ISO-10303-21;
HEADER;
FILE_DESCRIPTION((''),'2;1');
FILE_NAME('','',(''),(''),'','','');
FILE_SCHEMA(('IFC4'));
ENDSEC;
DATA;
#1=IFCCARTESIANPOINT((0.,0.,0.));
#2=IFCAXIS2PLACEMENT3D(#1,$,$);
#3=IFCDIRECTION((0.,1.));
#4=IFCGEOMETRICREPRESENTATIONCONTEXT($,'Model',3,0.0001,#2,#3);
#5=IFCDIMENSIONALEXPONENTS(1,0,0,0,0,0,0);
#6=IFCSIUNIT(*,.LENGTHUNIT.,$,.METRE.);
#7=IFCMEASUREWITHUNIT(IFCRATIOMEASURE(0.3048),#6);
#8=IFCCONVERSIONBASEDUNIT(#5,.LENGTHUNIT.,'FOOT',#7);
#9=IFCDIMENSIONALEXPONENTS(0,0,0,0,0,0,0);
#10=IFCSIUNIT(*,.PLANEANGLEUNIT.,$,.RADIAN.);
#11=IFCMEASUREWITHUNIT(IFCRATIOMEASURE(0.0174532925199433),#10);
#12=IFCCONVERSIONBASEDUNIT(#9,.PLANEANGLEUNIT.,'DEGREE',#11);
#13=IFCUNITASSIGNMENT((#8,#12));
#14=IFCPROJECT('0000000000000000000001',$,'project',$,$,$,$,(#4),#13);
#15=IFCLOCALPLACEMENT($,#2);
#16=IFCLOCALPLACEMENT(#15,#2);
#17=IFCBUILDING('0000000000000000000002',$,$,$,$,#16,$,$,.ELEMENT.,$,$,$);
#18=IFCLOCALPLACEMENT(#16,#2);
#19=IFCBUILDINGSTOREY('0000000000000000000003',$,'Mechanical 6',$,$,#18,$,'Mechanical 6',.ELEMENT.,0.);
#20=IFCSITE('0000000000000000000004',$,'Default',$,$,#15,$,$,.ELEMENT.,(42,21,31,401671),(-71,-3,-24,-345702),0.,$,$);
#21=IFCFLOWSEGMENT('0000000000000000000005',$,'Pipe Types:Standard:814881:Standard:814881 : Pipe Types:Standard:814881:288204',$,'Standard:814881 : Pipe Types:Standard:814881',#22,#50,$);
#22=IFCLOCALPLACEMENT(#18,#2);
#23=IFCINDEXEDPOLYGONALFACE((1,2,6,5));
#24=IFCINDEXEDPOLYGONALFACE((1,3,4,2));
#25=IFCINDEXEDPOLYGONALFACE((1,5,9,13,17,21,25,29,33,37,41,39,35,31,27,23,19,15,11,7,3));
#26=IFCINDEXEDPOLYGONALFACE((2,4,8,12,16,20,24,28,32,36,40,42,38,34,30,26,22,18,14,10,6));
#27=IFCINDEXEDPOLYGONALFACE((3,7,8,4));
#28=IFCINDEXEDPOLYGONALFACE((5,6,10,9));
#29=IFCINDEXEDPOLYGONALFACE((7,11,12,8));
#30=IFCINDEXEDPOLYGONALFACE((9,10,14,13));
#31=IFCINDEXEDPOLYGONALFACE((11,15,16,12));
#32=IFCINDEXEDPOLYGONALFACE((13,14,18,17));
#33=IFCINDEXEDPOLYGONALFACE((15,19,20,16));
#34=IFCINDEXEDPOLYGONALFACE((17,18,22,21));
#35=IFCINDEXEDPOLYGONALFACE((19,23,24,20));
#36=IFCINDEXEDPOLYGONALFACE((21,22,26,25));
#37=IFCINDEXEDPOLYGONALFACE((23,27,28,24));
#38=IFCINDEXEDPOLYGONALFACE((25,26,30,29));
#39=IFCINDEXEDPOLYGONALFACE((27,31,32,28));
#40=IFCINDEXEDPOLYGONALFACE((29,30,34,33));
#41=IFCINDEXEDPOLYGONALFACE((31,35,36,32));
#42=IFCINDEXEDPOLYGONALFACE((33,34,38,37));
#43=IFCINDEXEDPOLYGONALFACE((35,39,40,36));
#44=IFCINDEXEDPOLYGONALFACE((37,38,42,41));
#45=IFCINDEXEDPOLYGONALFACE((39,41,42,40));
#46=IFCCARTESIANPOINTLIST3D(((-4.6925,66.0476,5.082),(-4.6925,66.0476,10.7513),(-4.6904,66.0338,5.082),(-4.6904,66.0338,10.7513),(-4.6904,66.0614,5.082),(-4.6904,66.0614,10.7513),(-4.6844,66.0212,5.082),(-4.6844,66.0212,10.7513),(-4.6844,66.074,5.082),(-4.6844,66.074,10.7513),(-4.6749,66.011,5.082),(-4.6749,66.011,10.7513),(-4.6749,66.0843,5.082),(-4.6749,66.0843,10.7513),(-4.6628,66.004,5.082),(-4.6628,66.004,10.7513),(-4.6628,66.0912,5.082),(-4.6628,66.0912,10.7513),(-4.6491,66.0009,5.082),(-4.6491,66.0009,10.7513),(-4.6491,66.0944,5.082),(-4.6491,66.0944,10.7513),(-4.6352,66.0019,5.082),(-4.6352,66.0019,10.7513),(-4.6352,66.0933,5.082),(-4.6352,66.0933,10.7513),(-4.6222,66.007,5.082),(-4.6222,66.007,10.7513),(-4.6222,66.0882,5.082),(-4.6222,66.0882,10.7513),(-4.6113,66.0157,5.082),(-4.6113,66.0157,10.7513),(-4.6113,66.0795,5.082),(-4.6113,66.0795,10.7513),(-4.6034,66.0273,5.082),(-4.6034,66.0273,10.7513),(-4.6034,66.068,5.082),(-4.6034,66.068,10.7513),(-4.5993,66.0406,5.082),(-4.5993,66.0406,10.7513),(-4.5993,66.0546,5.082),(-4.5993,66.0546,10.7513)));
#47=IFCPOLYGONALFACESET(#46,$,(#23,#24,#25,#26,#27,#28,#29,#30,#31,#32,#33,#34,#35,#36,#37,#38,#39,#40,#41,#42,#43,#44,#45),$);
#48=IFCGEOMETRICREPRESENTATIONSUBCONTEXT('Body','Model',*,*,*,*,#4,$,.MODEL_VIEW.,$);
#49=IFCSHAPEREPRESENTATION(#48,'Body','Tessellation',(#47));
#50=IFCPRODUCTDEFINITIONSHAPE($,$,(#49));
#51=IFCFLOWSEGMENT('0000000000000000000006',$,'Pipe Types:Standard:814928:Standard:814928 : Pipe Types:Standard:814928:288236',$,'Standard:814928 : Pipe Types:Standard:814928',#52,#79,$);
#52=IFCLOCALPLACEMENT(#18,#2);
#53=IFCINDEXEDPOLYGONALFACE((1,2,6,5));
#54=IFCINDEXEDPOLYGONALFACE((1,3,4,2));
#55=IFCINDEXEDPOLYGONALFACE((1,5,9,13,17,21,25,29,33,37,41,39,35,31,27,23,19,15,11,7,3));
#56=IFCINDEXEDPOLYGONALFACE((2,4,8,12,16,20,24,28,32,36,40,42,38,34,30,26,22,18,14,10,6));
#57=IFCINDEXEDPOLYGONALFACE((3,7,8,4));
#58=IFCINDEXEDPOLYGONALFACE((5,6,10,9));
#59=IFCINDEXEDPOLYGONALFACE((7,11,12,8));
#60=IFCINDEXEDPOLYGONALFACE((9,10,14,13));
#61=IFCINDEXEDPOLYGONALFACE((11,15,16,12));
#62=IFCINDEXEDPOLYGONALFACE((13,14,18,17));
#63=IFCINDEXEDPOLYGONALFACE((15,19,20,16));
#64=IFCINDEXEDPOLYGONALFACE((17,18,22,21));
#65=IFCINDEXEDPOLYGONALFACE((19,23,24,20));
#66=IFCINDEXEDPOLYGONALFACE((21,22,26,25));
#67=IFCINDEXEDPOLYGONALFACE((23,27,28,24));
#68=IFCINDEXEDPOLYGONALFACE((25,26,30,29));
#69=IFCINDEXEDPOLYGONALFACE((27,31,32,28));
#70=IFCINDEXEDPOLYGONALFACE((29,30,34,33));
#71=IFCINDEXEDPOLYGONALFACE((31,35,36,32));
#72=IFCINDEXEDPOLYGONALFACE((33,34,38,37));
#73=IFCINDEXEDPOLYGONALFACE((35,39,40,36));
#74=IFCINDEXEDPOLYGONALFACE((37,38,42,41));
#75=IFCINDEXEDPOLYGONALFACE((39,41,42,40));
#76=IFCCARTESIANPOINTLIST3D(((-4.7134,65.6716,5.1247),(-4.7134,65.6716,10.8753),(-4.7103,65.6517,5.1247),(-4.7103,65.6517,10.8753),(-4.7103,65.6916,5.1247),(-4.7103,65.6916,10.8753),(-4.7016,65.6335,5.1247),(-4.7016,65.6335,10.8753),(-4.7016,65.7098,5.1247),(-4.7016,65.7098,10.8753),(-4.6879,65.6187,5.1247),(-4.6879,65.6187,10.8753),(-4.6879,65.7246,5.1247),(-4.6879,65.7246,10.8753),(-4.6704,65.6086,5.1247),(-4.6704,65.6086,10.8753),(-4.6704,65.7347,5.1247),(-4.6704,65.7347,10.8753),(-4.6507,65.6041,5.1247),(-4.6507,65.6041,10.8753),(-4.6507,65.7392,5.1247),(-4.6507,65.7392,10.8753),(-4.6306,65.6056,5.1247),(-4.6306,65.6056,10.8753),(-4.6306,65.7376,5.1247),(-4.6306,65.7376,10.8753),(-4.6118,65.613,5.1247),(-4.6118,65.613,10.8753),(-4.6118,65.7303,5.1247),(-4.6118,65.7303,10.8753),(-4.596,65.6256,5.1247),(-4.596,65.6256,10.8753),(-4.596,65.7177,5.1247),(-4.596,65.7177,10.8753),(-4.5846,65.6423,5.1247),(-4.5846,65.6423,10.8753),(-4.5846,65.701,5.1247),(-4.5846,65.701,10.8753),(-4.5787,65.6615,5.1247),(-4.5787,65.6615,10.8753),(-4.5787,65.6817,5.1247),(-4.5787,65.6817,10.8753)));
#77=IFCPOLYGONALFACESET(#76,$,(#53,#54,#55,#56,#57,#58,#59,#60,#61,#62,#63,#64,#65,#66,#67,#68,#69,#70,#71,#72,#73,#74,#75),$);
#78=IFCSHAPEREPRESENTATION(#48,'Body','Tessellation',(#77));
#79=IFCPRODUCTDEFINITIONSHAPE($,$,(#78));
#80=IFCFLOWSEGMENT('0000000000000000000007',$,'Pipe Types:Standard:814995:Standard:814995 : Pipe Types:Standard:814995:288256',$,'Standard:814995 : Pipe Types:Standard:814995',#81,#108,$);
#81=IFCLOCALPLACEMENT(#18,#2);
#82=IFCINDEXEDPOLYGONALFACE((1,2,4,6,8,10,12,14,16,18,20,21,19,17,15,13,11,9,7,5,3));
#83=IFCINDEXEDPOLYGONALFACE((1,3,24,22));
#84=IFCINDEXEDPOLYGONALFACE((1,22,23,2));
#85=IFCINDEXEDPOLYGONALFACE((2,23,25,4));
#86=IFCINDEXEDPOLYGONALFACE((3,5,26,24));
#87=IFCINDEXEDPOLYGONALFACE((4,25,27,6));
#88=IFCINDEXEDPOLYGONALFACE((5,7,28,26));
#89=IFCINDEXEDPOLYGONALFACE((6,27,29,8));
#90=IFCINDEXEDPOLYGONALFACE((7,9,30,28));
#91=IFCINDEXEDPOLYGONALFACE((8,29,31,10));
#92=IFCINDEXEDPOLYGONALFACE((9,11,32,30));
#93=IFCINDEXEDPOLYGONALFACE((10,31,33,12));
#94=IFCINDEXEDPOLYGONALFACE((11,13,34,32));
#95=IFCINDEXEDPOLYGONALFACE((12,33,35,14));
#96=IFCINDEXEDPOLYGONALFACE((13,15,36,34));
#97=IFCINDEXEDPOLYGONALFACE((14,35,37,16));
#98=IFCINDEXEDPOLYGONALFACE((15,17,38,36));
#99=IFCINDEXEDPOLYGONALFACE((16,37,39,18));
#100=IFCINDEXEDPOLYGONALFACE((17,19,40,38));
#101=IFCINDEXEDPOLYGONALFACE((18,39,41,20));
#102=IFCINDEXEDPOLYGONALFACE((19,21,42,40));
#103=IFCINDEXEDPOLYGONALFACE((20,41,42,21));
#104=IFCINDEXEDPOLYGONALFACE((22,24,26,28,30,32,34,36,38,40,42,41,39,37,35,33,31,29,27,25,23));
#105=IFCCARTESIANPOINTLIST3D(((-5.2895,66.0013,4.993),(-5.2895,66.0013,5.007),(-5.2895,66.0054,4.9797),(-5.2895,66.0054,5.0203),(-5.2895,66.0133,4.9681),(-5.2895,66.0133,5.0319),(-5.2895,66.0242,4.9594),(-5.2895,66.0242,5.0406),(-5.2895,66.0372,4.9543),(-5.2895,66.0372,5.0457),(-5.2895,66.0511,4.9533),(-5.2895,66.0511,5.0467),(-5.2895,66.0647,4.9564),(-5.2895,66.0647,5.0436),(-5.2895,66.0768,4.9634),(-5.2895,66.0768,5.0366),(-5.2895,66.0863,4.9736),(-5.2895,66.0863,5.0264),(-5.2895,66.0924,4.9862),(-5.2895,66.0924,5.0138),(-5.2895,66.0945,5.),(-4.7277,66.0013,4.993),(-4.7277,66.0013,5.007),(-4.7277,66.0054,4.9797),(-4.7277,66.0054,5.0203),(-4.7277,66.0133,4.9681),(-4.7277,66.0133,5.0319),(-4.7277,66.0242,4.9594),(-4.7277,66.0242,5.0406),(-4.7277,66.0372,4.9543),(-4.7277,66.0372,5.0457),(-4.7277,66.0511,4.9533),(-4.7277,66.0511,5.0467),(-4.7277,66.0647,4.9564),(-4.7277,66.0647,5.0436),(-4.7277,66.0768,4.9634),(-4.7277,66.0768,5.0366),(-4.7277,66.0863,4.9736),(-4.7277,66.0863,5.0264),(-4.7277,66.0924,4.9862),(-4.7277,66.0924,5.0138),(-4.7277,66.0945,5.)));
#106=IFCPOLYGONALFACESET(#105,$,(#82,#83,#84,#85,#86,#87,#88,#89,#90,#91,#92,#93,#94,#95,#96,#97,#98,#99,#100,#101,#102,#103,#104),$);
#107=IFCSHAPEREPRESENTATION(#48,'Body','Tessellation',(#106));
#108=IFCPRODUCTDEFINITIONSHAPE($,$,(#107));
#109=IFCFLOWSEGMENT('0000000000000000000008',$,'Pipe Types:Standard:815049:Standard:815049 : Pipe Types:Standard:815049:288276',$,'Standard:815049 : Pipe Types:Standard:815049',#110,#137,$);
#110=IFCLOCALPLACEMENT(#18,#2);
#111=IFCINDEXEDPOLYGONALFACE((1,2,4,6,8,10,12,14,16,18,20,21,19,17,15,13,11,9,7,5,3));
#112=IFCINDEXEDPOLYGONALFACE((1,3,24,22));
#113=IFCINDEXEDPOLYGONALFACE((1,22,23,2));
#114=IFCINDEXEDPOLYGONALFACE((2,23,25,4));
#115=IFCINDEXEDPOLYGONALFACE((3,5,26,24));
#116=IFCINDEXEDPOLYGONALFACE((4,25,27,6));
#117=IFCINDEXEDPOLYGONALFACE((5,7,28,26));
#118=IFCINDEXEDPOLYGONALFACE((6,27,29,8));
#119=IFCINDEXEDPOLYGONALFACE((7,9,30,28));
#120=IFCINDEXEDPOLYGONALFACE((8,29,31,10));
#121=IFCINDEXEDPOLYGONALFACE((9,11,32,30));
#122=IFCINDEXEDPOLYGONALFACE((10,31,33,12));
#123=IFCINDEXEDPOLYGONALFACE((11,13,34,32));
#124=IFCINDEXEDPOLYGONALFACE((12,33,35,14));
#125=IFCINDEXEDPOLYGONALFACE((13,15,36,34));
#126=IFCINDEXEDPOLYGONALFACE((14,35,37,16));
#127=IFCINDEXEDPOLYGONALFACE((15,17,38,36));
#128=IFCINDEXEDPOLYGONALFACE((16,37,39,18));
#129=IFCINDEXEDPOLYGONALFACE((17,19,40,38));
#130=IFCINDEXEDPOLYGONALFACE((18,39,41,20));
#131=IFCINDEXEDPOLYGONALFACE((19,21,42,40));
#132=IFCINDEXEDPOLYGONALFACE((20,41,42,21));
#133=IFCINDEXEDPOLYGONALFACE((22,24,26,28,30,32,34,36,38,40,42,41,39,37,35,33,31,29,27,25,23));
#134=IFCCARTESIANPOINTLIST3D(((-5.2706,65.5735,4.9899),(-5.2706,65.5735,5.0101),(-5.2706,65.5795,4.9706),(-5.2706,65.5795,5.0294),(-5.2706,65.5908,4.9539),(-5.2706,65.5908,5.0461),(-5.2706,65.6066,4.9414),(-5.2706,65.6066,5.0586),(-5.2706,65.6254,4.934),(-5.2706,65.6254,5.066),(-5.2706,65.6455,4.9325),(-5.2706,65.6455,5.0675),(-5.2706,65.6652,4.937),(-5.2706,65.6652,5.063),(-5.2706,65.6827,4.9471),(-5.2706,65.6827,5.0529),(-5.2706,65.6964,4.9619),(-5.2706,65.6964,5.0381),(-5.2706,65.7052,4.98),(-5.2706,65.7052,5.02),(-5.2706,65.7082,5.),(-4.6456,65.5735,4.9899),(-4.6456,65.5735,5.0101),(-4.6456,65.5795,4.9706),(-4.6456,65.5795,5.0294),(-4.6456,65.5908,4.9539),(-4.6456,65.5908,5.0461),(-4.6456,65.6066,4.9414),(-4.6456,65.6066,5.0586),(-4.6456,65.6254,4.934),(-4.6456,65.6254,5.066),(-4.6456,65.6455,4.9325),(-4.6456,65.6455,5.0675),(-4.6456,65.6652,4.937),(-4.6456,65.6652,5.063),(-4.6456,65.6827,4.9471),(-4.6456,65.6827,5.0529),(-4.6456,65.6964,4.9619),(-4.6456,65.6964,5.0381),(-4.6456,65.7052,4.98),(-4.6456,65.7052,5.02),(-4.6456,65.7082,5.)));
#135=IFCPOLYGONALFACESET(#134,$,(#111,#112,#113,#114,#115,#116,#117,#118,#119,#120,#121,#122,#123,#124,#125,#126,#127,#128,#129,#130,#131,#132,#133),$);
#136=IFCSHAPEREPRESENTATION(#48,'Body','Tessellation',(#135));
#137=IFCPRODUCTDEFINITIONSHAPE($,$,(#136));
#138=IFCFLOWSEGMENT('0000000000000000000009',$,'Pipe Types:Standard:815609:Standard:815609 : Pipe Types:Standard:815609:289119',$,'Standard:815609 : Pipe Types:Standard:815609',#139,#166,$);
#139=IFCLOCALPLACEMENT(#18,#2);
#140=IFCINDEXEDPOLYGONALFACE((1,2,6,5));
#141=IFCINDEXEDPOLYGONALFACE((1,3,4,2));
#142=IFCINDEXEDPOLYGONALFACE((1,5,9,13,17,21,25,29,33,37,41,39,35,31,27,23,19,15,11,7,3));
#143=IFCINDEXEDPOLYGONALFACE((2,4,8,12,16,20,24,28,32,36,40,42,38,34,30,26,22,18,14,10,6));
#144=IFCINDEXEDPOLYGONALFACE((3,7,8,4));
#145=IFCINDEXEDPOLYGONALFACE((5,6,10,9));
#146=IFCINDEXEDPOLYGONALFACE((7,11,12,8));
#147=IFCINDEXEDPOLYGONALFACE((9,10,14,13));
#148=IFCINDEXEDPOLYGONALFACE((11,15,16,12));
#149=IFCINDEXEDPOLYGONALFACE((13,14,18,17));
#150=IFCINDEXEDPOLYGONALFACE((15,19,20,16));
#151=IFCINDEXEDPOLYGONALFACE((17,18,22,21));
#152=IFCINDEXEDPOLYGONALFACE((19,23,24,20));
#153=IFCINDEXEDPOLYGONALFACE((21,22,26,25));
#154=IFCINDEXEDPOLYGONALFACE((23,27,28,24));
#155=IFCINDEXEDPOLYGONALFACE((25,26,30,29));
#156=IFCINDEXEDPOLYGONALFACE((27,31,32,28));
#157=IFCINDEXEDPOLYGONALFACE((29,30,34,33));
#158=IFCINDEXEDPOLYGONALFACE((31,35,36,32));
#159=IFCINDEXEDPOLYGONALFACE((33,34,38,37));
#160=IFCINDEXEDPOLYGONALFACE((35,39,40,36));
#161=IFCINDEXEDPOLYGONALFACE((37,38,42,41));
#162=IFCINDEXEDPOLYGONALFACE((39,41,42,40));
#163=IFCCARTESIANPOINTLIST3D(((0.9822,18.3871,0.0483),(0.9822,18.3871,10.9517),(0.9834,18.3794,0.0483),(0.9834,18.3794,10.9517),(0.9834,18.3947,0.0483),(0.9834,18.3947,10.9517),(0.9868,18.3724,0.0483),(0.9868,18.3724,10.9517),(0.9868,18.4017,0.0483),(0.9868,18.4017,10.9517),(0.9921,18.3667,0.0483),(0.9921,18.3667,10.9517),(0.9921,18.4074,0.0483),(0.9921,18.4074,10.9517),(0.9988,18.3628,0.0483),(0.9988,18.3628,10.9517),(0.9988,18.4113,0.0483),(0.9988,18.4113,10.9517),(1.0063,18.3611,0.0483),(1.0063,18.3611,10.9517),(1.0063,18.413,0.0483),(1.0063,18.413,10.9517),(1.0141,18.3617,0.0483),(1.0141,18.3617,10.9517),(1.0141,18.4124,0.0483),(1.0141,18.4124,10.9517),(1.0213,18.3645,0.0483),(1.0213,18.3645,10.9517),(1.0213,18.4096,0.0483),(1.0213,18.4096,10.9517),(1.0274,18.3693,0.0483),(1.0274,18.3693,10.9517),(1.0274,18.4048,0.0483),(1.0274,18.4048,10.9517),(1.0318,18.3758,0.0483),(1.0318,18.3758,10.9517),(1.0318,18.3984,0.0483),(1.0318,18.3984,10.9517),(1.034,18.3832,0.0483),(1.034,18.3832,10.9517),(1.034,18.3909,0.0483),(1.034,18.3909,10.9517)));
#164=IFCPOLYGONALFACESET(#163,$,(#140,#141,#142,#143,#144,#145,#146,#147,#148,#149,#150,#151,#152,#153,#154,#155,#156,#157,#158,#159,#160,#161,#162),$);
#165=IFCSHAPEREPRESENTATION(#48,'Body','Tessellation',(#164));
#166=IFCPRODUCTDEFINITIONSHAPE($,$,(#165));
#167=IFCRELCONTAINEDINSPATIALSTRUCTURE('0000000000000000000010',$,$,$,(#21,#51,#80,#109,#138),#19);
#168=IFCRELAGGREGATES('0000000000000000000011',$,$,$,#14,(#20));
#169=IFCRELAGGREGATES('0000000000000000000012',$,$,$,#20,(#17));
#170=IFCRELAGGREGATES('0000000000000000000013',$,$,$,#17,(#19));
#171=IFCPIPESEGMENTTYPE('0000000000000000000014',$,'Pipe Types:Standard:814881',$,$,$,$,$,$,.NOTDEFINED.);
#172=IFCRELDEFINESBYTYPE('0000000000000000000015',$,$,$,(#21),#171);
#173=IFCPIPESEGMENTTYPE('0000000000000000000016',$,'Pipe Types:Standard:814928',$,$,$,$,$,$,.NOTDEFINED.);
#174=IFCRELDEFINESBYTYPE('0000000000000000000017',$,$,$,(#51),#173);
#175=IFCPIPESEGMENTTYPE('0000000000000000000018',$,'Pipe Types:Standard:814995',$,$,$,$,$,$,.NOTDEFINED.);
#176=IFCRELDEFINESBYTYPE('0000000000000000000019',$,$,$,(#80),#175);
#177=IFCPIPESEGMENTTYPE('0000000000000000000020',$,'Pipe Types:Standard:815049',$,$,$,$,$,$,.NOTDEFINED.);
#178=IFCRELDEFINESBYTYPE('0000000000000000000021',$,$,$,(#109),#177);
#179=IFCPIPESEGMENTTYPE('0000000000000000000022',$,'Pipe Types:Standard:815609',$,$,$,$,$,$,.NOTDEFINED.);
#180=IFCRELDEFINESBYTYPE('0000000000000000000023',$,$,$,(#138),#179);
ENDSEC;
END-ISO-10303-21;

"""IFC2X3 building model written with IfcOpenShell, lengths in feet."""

from ifc_helpers import new_model, entity, si_unit, converted_unit, direction, frame, origin, origin_2d_with_axis, place, context, subcontext, project, spatial, circle, extrude, source, transform, mapped, type_object, type_shapes, element, save


model = new_model("IFC2X3")

# Units and contexts
model_context = context("Model", 3, precision=0.0001, world=origin(), true_north=direction((0.0, 1.0)))
body_context = subcontext(model_context, "Body", "Model", "MODEL_VIEW")
ifc_project = project(units=[converted_unit("LENGTHUNIT", "FOOT", entity("IfcRatioMeasure", 0.3048), si_unit("LENGTHUNIT", "METRE"), dimensions=[1, 0, 0, 0, 0, 0, 0]), converted_unit("PLANEANGLEUNIT", "DEGREE", entity("IfcRatioMeasure", 0.0174532925199433), si_unit("PLANEANGLEUNIT", "RADIAN"), dimensions=[0, 0, 0, 0, 0, 0, 0])], contexts=[model_context])

# Site, building, storey
site_placement = place(None, origin())
site = spatial("IfcSite", under=ifc_project, at=site_placement, Name="Default", CompositionType="ELEMENT", RefLatitude=(42, 21, 31, 401671), RefLongitude=(-71, -3, -24, -345702), RefElevation=0.0)
building_placement = place(site_placement, origin())
building = spatial("IfcBuilding", under=site, at=building_placement, CompositionType="ELEMENT")
storey_placement = place(building_placement, origin())
storey = spatial("IfcBuildingStorey", under=building, at=storey_placement, Name="Mechanical 6", LongName="Mechanical 6", CompositionType="ELEMENT", Elevation=0.0)

# Flow segments
pipe_segment_type_1 = type_object("IfcPipeSegmentType", Name="Pipe Types:Standard:814881", PredefinedType="NOTDEFINED")
shared_shape_1 = source(origin(), body_context, "Body", "SweptSolid", [
    extrude(circle(Radius=0.0469, at=origin_2d_with_axis()), frame((-4.6456, 66.0476, 5.082), z_axis=(0.0, 0.0, 1.0), x_axis=(-1.0, 0.0, 0.0)), (0.0, 0.0, 1.0), 5.6693),
])
type_shapes(pipe_segment_type_1, [shared_shape_1])
flow_segment_1_placement = place(building_placement, origin())
element("IfcFlowSegment", 1, at=flow_segment_1_placement, inside=storey, type_object=pipe_segment_type_1, Name="Pipe Types:Standard:814881:Standard:814881 : Pipe Types:Standard:814881:288204", ObjectType="Standard:814881 : Pipe Types:Standard:814881", context=body_context, shape_type="MappedRepresentation", body=[
    mapped(shared_shape_1, transform((0.0, 0.0, 0.0), scale=1.0)),
])
pipe_segment_type_2 = type_object("IfcPipeSegmentType", Name="Pipe Types:Standard:814928", PredefinedType="NOTDEFINED")
shared_shape_2 = source(origin(), body_context, "Body", "SweptSolid", [
    extrude(circle(Radius=0.0677, at=origin_2d_with_axis()), frame((-4.6456, 65.6716, 5.1247), z_axis=(0.0, 0.0, 1.0), x_axis=(-1.0, 0.0, 0.0)), (0.0, 0.0, 1.0), 5.7507),
])
type_shapes(pipe_segment_type_2, [shared_shape_2])
flow_segment_2_placement = place(building_placement, origin())
element("IfcFlowSegment", 2, at=flow_segment_2_placement, inside=storey, type_object=pipe_segment_type_2, Name="Pipe Types:Standard:814928:Standard:814928 : Pipe Types:Standard:814928:288236", ObjectType="Standard:814928 : Pipe Types:Standard:814928", context=body_context, shape_type="MappedRepresentation", body=[
    mapped(shared_shape_2, transform((0.0, 0.0, 0.0), scale=1.0)),
])
pipe_segment_type_3 = type_object("IfcPipeSegmentType", Name="Pipe Types:Standard:814995", PredefinedType="NOTDEFINED")
shared_shape_3 = source(origin(), body_context, "Body", "SweptSolid", [
    extrude(circle(Radius=0.0469, at=origin_2d_with_axis()), frame((-5.2895, 66.0476, 5.0), z_axis=(1.0, 0.0, 0.0), x_axis=(0.0, 1.0, 0.0)), (0.0, 0.0, 1.0), 0.5618),
])
type_shapes(pipe_segment_type_3, [shared_shape_3])
flow_segment_3_placement = place(building_placement, origin())
element("IfcFlowSegment", 3, at=flow_segment_3_placement, inside=storey, type_object=pipe_segment_type_3, Name="Pipe Types:Standard:814995:Standard:814995 : Pipe Types:Standard:814995:288256", ObjectType="Standard:814995 : Pipe Types:Standard:814995", context=body_context, shape_type="MappedRepresentation", body=[
    mapped(shared_shape_3, transform((0.0, 0.0, 0.0), scale=1.0)),
])
pipe_segment_type_4 = type_object("IfcPipeSegmentType", Name="Pipe Types:Standard:815049", PredefinedType="NOTDEFINED")
shared_shape_4 = source(origin(), body_context, "Body", "SweptSolid", [
    extrude(circle(Radius=0.0677, at=origin_2d_with_axis()), frame((-5.2706, 65.6405, 5.0), z_axis=(1.0, 0.0, 0.0), x_axis=(0.0, 1.0, 0.0)), (0.0, 0.0, 1.0), 0.625),
])
type_shapes(pipe_segment_type_4, [shared_shape_4])
flow_segment_4_placement = place(building_placement, origin())
element("IfcFlowSegment", 4, at=flow_segment_4_placement, inside=storey, type_object=pipe_segment_type_4, Name="Pipe Types:Standard:815049:Standard:815049 : Pipe Types:Standard:815049:288276", ObjectType="Standard:815049 : Pipe Types:Standard:815049", context=body_context, shape_type="MappedRepresentation", body=[
    mapped(shared_shape_4, transform((0.0, 0.0, 0.0), scale=1.0)),
])
pipe_segment_type_5 = type_object("IfcPipeSegmentType", Name="Pipe Types:Standard:815609", PredefinedType="NOTDEFINED")
shared_shape_5 = source(origin(), body_context, "Body", "SweptSolid", [
    extrude(circle(Radius=0.026, at=origin_2d_with_axis()), frame((1.0083, 18.3871, 0.0483), z_axis=(0.0, 0.0, 1.0), x_axis=(-1.0, 0.0, 0.0)), (0.0, 0.0, 1.0), 10.9033),
])
type_shapes(pipe_segment_type_5, [shared_shape_5])
flow_segment_5_placement = place(building_placement, origin())
element("IfcFlowSegment", 5, at=flow_segment_5_placement, inside=storey, type_object=pipe_segment_type_5, Name="Pipe Types:Standard:815609:Standard:815609 : Pipe Types:Standard:815609:289119", ObjectType="Standard:815609 : Pipe Types:Standard:815609", context=body_context, shape_type="MappedRepresentation", body=[
    mapped(shared_shape_5, transform((0.0, 0.0, 0.0), scale=1.0)),
])

save(model, "model.ifc")
